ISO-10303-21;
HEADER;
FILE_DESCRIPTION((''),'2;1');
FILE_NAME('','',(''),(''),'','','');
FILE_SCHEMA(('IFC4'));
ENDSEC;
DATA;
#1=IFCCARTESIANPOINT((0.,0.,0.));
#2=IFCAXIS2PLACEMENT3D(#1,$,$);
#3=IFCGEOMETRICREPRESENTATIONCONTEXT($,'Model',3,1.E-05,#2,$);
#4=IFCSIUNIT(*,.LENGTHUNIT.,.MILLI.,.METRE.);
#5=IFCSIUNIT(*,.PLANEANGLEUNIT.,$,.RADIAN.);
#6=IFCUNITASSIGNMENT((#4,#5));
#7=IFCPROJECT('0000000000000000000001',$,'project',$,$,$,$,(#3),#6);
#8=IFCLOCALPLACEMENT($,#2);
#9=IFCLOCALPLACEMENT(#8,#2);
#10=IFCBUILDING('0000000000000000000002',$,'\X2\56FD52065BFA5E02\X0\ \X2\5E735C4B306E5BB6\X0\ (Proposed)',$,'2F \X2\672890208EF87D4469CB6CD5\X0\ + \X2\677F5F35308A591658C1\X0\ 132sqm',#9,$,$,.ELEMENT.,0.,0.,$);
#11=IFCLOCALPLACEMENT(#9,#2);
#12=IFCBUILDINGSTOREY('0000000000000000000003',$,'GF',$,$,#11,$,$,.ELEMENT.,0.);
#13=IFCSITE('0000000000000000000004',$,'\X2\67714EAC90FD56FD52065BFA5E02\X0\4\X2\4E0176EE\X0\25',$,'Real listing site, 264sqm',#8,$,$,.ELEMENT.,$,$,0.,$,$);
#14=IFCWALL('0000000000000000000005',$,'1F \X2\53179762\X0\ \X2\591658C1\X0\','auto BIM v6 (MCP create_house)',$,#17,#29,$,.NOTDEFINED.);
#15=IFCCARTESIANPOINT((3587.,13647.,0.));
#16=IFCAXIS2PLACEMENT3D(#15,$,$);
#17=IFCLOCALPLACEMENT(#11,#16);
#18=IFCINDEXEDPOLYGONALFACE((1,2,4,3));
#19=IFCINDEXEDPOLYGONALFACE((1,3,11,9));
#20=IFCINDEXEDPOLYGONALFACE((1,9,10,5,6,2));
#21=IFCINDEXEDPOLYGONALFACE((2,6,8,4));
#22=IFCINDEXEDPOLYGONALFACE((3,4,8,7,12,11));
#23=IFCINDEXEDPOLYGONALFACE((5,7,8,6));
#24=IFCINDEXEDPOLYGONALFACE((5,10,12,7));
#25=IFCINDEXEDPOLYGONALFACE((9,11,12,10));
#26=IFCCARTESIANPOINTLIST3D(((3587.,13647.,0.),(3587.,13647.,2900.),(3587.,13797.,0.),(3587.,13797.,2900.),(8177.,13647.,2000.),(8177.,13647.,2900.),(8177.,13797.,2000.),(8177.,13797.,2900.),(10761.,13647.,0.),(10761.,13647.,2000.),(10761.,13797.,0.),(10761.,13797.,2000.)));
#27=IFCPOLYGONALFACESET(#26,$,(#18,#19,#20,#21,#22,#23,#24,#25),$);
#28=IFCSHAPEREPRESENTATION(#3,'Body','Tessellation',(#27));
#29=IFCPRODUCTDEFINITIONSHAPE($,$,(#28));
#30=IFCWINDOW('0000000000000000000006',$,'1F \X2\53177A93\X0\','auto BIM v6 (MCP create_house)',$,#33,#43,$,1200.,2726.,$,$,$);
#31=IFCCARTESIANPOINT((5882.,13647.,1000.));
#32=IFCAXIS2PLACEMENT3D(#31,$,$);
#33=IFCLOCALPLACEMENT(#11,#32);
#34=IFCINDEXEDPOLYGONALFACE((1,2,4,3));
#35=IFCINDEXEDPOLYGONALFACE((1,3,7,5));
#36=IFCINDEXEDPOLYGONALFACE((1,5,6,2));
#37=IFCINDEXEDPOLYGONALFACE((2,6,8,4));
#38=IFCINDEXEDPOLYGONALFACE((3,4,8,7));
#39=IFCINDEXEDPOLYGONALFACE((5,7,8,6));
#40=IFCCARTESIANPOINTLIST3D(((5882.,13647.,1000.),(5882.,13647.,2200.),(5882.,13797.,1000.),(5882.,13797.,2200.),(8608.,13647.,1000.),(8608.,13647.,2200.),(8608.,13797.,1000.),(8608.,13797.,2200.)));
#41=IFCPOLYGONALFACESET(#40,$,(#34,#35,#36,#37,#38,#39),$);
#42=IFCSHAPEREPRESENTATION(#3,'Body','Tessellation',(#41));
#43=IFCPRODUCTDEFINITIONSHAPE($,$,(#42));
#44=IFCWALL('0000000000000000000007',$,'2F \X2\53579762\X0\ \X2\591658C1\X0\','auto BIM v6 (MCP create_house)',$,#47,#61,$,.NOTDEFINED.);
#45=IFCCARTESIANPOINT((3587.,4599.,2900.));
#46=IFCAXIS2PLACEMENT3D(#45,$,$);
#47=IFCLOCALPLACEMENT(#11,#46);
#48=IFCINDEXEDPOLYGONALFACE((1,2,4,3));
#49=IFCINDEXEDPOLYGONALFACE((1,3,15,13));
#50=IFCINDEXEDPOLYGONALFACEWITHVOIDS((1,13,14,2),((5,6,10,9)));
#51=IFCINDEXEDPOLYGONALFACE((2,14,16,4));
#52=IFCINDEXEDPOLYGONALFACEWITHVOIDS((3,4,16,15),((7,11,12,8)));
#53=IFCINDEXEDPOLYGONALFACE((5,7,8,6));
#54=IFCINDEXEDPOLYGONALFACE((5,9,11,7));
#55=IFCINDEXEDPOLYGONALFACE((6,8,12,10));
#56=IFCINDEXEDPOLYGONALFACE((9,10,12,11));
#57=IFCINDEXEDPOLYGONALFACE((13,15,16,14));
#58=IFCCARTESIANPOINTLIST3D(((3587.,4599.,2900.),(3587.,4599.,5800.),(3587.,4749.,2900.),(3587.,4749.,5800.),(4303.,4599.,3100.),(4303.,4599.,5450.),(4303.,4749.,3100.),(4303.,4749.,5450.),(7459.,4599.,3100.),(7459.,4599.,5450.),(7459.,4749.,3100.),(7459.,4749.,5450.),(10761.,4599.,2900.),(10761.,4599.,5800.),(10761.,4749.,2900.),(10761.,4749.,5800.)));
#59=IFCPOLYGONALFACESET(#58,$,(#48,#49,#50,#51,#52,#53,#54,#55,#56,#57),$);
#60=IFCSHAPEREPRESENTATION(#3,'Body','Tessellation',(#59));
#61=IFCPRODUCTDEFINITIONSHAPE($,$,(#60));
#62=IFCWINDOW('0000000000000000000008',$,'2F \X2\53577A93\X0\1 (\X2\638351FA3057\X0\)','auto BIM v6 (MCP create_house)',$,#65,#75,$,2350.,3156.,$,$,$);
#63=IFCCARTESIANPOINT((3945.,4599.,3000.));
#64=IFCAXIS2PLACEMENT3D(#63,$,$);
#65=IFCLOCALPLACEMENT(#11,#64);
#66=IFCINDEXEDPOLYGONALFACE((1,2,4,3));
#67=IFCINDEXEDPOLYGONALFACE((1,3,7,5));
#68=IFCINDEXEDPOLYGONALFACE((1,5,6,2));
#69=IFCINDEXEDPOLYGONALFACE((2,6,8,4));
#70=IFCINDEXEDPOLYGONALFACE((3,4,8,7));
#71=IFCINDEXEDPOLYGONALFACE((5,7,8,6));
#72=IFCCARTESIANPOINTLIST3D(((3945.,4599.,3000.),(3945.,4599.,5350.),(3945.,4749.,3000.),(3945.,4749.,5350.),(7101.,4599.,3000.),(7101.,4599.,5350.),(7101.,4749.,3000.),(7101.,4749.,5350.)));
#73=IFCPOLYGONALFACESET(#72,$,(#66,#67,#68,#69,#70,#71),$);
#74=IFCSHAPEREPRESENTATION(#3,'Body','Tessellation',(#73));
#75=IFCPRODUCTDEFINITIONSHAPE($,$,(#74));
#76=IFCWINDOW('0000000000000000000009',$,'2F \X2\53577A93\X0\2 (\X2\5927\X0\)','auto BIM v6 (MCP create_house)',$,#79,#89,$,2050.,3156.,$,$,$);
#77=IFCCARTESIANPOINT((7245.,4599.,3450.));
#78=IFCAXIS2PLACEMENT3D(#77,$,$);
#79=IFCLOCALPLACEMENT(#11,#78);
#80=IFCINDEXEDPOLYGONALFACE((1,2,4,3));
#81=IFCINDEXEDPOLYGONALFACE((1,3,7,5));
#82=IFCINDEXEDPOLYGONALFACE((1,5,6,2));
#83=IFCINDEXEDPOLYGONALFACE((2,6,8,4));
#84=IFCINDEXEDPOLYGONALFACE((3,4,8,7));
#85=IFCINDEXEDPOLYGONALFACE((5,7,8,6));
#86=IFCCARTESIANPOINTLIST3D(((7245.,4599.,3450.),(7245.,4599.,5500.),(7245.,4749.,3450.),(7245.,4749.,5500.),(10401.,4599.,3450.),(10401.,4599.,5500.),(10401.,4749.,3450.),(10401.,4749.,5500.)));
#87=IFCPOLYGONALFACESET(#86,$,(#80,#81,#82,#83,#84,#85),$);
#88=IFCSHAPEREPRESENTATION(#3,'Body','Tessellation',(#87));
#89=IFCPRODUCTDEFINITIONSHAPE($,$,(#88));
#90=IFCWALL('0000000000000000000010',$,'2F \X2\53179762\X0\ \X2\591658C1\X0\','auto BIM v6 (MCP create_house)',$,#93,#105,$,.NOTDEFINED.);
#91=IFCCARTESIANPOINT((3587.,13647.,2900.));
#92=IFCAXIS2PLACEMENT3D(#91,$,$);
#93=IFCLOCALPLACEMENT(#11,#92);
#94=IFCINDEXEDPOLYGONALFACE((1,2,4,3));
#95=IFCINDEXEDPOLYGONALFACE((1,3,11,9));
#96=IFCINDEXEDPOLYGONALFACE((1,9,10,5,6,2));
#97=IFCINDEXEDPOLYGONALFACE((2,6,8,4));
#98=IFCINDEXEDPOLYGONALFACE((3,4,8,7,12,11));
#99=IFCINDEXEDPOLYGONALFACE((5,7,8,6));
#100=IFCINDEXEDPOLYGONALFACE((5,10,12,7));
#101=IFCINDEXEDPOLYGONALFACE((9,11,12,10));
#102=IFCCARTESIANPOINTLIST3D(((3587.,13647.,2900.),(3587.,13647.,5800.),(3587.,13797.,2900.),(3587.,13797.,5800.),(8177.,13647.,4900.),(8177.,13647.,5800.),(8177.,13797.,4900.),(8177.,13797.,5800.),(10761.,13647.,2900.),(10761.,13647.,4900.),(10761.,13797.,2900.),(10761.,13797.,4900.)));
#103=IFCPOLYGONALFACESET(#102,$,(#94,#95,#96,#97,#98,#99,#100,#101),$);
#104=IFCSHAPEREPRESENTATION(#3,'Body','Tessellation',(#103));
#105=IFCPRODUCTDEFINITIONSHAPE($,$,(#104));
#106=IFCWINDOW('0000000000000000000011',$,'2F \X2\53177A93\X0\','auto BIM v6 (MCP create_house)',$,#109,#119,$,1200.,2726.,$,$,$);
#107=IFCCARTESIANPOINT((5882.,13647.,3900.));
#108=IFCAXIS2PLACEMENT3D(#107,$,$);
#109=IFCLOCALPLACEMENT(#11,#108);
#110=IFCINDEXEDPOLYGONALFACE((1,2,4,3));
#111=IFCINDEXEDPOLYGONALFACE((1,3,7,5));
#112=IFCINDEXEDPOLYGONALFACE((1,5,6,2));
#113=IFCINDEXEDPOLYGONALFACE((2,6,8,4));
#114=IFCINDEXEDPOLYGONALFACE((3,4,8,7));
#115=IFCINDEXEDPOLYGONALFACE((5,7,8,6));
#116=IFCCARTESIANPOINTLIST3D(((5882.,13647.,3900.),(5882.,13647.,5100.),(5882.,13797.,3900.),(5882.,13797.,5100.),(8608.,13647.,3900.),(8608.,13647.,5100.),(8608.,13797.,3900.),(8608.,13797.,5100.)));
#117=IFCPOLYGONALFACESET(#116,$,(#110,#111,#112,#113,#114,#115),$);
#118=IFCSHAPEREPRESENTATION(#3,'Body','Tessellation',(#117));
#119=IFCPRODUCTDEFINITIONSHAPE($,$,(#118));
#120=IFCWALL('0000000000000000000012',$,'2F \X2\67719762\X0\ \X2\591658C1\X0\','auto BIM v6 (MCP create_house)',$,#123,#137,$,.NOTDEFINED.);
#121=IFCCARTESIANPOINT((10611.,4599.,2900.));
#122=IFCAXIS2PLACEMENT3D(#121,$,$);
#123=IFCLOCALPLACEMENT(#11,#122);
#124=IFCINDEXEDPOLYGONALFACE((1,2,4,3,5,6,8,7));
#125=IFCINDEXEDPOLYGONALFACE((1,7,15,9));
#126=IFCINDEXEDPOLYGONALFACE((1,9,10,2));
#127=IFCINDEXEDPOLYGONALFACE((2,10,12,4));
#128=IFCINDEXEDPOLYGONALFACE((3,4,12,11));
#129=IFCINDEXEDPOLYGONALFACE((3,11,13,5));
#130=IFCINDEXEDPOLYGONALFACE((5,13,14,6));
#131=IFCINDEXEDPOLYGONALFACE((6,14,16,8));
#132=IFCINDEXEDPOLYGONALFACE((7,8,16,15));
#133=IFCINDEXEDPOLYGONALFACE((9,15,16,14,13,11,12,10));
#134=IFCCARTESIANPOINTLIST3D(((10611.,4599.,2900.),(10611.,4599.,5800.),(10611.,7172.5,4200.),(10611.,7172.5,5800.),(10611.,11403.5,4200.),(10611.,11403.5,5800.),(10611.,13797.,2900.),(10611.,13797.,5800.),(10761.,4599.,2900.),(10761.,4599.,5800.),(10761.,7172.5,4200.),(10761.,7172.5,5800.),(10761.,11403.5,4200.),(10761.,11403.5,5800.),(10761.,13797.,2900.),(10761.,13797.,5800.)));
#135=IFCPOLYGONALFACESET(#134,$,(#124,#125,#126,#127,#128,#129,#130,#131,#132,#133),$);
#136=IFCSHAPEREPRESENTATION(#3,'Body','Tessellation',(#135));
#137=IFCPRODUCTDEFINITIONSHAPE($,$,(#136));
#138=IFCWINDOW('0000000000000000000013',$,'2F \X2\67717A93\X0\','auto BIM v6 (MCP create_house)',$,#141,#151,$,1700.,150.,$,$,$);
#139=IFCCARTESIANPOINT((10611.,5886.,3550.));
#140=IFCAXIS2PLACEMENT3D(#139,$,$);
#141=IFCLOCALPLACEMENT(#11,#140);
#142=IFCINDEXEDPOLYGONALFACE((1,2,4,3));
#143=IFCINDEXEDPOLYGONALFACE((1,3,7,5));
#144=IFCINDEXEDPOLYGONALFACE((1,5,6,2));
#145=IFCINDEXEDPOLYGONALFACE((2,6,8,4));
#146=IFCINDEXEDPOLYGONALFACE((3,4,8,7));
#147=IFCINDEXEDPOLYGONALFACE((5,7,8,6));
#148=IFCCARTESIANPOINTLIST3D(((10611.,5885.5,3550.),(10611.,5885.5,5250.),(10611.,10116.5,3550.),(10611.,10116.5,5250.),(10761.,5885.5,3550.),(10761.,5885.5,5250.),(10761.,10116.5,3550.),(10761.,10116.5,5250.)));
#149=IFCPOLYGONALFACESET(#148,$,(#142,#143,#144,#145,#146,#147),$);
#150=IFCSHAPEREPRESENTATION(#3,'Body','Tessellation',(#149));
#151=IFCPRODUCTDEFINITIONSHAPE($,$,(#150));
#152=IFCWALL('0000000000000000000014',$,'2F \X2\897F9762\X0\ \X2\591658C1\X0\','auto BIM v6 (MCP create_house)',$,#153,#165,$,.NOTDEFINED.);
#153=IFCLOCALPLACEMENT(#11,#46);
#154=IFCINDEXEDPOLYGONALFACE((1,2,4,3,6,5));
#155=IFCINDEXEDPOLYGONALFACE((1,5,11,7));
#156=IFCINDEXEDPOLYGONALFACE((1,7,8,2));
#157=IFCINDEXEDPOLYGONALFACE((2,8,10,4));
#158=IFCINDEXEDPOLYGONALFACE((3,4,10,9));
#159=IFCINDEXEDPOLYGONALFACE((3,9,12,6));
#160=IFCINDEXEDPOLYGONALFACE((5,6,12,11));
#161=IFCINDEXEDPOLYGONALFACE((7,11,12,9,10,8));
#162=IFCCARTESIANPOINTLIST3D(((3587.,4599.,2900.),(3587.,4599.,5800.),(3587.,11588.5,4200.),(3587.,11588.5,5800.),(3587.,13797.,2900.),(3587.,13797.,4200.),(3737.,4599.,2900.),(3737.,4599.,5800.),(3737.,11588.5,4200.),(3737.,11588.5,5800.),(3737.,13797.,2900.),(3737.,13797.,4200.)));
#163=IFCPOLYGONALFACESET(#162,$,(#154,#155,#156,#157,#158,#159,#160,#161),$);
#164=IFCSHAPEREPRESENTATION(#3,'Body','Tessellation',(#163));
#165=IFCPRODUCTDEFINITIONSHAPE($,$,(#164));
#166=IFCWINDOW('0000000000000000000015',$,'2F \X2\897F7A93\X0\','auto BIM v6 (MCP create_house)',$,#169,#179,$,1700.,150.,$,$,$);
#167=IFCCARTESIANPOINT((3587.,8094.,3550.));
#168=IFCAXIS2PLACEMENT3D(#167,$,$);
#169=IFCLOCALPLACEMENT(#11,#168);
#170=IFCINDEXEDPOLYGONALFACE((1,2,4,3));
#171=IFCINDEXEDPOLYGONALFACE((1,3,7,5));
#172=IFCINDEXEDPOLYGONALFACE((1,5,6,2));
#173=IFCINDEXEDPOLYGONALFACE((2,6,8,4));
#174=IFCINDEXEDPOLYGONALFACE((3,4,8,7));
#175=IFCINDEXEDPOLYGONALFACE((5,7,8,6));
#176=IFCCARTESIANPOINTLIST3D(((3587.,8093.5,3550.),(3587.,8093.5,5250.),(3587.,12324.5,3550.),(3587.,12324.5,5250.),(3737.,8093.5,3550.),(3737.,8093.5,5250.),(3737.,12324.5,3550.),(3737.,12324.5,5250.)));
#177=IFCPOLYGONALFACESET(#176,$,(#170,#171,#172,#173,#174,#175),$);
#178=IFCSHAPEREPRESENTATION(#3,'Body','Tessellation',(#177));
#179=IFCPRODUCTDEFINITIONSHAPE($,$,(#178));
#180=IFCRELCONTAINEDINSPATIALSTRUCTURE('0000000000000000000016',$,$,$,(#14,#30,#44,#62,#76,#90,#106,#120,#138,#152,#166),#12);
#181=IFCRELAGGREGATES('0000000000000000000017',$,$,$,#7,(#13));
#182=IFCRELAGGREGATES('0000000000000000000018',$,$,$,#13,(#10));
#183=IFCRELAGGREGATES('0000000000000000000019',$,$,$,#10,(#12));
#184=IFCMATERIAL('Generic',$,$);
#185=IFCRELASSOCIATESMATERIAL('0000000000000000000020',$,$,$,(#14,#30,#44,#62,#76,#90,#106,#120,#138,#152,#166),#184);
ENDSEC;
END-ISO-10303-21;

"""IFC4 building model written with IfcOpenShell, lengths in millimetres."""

from ifc_helpers import new_model, si_unit, frame, frame_2d, origin, place, context, project, spatial, rectangle, extrude, material, element, fill, save


model = new_model("IFC4")

# Units and contexts
model_context = context("Model", 3, precision=1e-05, world=origin())
ifc_project = project(units=[si_unit("LENGTHUNIT", "METRE", prefix="MILLI"), si_unit("PLANEANGLEUNIT", "RADIAN")], contexts=[model_context])

# Site, building, storey
site_placement = place(None, origin())
site = spatial("IfcSite", under=ifc_project, at=site_placement, Name="東京都国分寺市4丁目25", ObjectType="Real listing site, 264sqm", CompositionType="ELEMENT", RefElevation=0.0)
building_placement = place(site_placement, origin())
building = spatial("IfcBuilding", under=site, at=building_placement, Name="国分寺市 平屋の家 (Proposed)", ObjectType="2F 木造軸組構法 + 板張り外壁 132sqm", CompositionType="ELEMENT", ElevationOfRefHeight=0.0, ElevationOfTerrain=0.0)
storey_placement = place(building_placement, origin())
storey = spatial("IfcBuildingStorey", under=building, at=storey_placement, Name="GF", CompositionType="ELEMENT", Elevation=0.0)

# Wall, opening, window
ifc_material = material(Name="Generic")
wall_1_placement = place(storey_placement, frame((3587.0, 13647.0, 0.0)))
wall_1 = element("IfcWall", 1, at=wall_1_placement, inside=storey, material=ifc_material, Name="1F 北面 外壁", Description="auto BIM v6 (MCP create_house)", PredefinedType="NOTDEFINED", context=model_context, shape_type="SweptSolid", body=[
    extrude(rectangle(XDim=7174.0, YDim=150.0, at=frame_2d((3587.0, 75.0))), frame((3587.0, 13647.0, 0.0)), (0.0, 0.0, 1.0), 2900.0),
])
opening_1_placement = place(storey_placement, frame((5882.0, 13647.0, 1000.0)))
opening_1 = element("IfcOpeningElement", 2, at=opening_1_placement, cuts=wall_1, PredefinedType="NOTDEFINED", context=model_context, shape_type="SweptSolid", body=[
    extrude(rectangle(XDim=2726.0, YDim=150.0, at=frame_2d((1363.0, 75.0))), frame((5882.0, 13647.0, 1000.0)), (0.0, 0.0, 1.0), 1200.0),
])
window_1_placement = place(storey_placement, frame((5882.0, 13647.0, 1000.0)))
window_1 = element("IfcWindow", 3, at=window_1_placement, inside=storey, material=ifc_material, Name="1F 北窓", Description="auto BIM v6 (MCP create_house)", OverallHeight=1200.0, OverallWidth=2726.0, context=model_context, shape_type="SweptSolid", body=[
    extrude(rectangle(XDim=2726.0, YDim=150.0, at=frame_2d((1363.0, 75.0))), frame((5882.0, 13647.0, 1000.0)), (0.0, 0.0, 1.0), 1200.0),
])
fill(opening_1, window_1)

# Wall, openings, windows
wall_2_placement = place(storey_placement, frame((3587.0, 4599.0, 2900.0)))
wall_2 = element("IfcWall", 4, at=wall_2_placement, inside=storey, material=ifc_material, Name="2F 南面 外壁", Description="auto BIM v6 (MCP create_house)", PredefinedType="NOTDEFINED", context=model_context, shape_type="SweptSolid", body=[
    extrude(rectangle(XDim=7174.0, YDim=150.0, at=frame_2d((3587.0, 75.0))), frame((3587.0, 4599.0, 2900.0)), (0.0, 0.0, 1.0), 2900.0),
])
opening_2_placement = place(storey_placement, frame((3945.0, 4599.0, 3000.0)))
opening_2 = element("IfcOpeningElement", 5, at=opening_2_placement, cuts=wall_2, PredefinedType="NOTDEFINED", context=model_context, shape_type="SweptSolid", body=[
    extrude(rectangle(XDim=3156.0, YDim=150.0, at=frame_2d((1578.0, 75.0))), frame((3945.0, 4599.0, 3000.0)), (0.0, 0.0, 1.0), 2350.0),
])
opening_3_placement = place(storey_placement, frame((7245.0, 4599.0, 3450.0)))
opening_3 = element("IfcOpeningElement", 6, at=opening_3_placement, cuts=wall_2, PredefinedType="NOTDEFINED", context=model_context, shape_type="SweptSolid", body=[
    extrude(rectangle(XDim=3156.0, YDim=150.0, at=frame_2d((1578.0, 75.0))), frame((7245.0, 4599.0, 3450.0)), (0.0, 0.0, 1.0), 2050.0),
])
window_2_placement = place(storey_placement, frame((3945.0, 4599.0, 3000.0)))
window_2 = element("IfcWindow", 7, at=window_2_placement, inside=storey, material=ifc_material, Name="2F 南窓1 (掃出し)", Description="auto BIM v6 (MCP create_house)", OverallHeight=2350.0, OverallWidth=3156.0, context=model_context, shape_type="SweptSolid", body=[
    extrude(rectangle(XDim=3156.0, YDim=150.0, at=frame_2d((1578.0, 75.0))), frame((3945.0, 4599.0, 3000.0)), (0.0, 0.0, 1.0), 2350.0),
])
fill(opening_2, window_2)
window_3_placement = place(storey_placement, frame((7245.0, 4599.0, 3450.0)))
window_3 = element("IfcWindow", 8, at=window_3_placement, inside=storey, material=ifc_material, Name="2F 南窓2 (大)", Description="auto BIM v6 (MCP create_house)", OverallHeight=2050.0, OverallWidth=3156.0, context=model_context, shape_type="SweptSolid", body=[
    extrude(rectangle(XDim=3156.0, YDim=150.0, at=frame_2d((1578.0, 75.0))), frame((7245.0, 4599.0, 3450.0)), (0.0, 0.0, 1.0), 2050.0),
])
fill(opening_3, window_3)

# Walls, openings, windows
wall_3_placement = place(storey_placement, frame((3587.0, 13647.0, 2900.0)))
wall_3 = element("IfcWall", 9, at=wall_3_placement, inside=storey, material=ifc_material, Name="2F 北面 外壁", Description="auto BIM v6 (MCP create_house)", PredefinedType="NOTDEFINED", context=model_context, shape_type="SweptSolid", body=[
    extrude(rectangle(XDim=7174.0, YDim=150.0, at=frame_2d((3587.0, 75.0))), frame((3587.0, 13647.0, 2900.0)), (0.0, 0.0, 1.0), 2900.0),
])
opening_4_placement = place(storey_placement, frame((5882.0, 13647.0, 3900.0)))
opening_4 = element("IfcOpeningElement", 10, at=opening_4_placement, cuts=wall_3, PredefinedType="NOTDEFINED", context=model_context, shape_type="SweptSolid", body=[
    extrude(rectangle(XDim=2726.0, YDim=150.0, at=frame_2d((1363.0, 75.0))), frame((5882.0, 13647.0, 3900.0)), (0.0, 0.0, 1.0), 1200.0),
])
window_4_placement = place(storey_placement, frame((5882.0, 13647.0, 3900.0)))
window_4 = element("IfcWindow", 11, at=window_4_placement, inside=storey, material=ifc_material, Name="2F 北窓", Description="auto BIM v6 (MCP create_house)", OverallHeight=1200.0, OverallWidth=2726.0, context=model_context, shape_type="SweptSolid", body=[
    extrude(rectangle(XDim=2726.0, YDim=150.0, at=frame_2d((1363.0, 75.0))), frame((5882.0, 13647.0, 3900.0)), (0.0, 0.0, 1.0), 1200.0),
])
fill(opening_4, window_4)
wall_4_placement = place(storey_placement, frame((10611.0, 4599.0, 2900.0)))
wall_4 = element("IfcWall", 12, at=wall_4_placement, inside=storey, material=ifc_material, Name="2F 東面 外壁", Description="auto BIM v6 (MCP create_house)", PredefinedType="NOTDEFINED", context=model_context, shape_type="SweptSolid", body=[
    extrude(rectangle(XDim=150.0, YDim=9198.0, at=frame_2d((75.0, 4599.0))), frame((10611.0, 4599.0, 2900.0)), (0.0, 0.0, 1.0), 2900.0),
])
opening_5_placement = place(storey_placement, frame((10611.0, 5886.0, 3550.0)))
opening_5 = element("IfcOpeningElement", 13, at=opening_5_placement, cuts=wall_4, PredefinedType="NOTDEFINED", context=model_context, shape_type="SweptSolid", body=[
    extrude(rectangle(XDim=150.0, YDim=4231.0, at=frame_2d((75.0, 2115.0))), frame((10611.0, 5886.0, 3550.0)), (0.0, 0.0, 1.0), 1700.0),
])
window_5_placement = place(storey_placement, frame((10611.0, 5886.0, 3550.0)))
window_5 = element("IfcWindow", 14, at=window_5_placement, inside=storey, material=ifc_material, Name="2F 東窓", Description="auto BIM v6 (MCP create_house)", OverallHeight=1700.0, OverallWidth=150.0, context=model_context, shape_type="SweptSolid", body=[
    extrude(rectangle(XDim=150.0, YDim=4231.0, at=frame_2d((75.0, 2115.0))), frame((10611.0, 5886.0, 3550.0)), (0.0, 0.0, 1.0), 1700.0),
])
fill(opening_5, window_5)
wall_5_placement = place(storey_placement, frame((3587.0, 4599.0, 2900.0)))
wall_5 = element("IfcWall", 15, at=wall_5_placement, inside=storey, material=ifc_material, Name="2F 西面 外壁", Description="auto BIM v6 (MCP create_house)", PredefinedType="NOTDEFINED", context=model_context, shape_type="SweptSolid", body=[
    extrude(rectangle(XDim=150.0, YDim=9198.0, at=frame_2d((75.0, 4599.0))), frame((3587.0, 4599.0, 2900.0)), (0.0, 0.0, 1.0), 2900.0),
])
opening_6_placement = place(storey_placement, frame((3587.0, 8094.0, 3550.0)))
opening_6 = element("IfcOpeningElement", 16, at=opening_6_placement, cuts=wall_5, PredefinedType="NOTDEFINED", context=model_context, shape_type="SweptSolid", body=[
    extrude(rectangle(XDim=150.0, YDim=4231.0, at=frame_2d((75.0, 2115.0))), frame((3587.0, 8094.0, 3550.0)), (0.0, 0.0, 1.0), 1700.0),
])
window_6_placement = place(storey_placement, frame((3587.0, 8094.0, 3550.0)))
window_6 = element("IfcWindow", 17, at=window_6_placement, inside=storey, material=ifc_material, Name="2F 西窓", Description="auto BIM v6 (MCP create_house)", OverallHeight=1700.0, OverallWidth=150.0, context=model_context, shape_type="SweptSolid", body=[
    extrude(rectangle(XDim=150.0, YDim=4231.0, at=frame_2d((75.0, 2115.0))), frame((3587.0, 8094.0, 3550.0)), (0.0, 0.0, 1.0), 1700.0),
])
fill(opening_6, window_6)

save(model, "model.ifc")
